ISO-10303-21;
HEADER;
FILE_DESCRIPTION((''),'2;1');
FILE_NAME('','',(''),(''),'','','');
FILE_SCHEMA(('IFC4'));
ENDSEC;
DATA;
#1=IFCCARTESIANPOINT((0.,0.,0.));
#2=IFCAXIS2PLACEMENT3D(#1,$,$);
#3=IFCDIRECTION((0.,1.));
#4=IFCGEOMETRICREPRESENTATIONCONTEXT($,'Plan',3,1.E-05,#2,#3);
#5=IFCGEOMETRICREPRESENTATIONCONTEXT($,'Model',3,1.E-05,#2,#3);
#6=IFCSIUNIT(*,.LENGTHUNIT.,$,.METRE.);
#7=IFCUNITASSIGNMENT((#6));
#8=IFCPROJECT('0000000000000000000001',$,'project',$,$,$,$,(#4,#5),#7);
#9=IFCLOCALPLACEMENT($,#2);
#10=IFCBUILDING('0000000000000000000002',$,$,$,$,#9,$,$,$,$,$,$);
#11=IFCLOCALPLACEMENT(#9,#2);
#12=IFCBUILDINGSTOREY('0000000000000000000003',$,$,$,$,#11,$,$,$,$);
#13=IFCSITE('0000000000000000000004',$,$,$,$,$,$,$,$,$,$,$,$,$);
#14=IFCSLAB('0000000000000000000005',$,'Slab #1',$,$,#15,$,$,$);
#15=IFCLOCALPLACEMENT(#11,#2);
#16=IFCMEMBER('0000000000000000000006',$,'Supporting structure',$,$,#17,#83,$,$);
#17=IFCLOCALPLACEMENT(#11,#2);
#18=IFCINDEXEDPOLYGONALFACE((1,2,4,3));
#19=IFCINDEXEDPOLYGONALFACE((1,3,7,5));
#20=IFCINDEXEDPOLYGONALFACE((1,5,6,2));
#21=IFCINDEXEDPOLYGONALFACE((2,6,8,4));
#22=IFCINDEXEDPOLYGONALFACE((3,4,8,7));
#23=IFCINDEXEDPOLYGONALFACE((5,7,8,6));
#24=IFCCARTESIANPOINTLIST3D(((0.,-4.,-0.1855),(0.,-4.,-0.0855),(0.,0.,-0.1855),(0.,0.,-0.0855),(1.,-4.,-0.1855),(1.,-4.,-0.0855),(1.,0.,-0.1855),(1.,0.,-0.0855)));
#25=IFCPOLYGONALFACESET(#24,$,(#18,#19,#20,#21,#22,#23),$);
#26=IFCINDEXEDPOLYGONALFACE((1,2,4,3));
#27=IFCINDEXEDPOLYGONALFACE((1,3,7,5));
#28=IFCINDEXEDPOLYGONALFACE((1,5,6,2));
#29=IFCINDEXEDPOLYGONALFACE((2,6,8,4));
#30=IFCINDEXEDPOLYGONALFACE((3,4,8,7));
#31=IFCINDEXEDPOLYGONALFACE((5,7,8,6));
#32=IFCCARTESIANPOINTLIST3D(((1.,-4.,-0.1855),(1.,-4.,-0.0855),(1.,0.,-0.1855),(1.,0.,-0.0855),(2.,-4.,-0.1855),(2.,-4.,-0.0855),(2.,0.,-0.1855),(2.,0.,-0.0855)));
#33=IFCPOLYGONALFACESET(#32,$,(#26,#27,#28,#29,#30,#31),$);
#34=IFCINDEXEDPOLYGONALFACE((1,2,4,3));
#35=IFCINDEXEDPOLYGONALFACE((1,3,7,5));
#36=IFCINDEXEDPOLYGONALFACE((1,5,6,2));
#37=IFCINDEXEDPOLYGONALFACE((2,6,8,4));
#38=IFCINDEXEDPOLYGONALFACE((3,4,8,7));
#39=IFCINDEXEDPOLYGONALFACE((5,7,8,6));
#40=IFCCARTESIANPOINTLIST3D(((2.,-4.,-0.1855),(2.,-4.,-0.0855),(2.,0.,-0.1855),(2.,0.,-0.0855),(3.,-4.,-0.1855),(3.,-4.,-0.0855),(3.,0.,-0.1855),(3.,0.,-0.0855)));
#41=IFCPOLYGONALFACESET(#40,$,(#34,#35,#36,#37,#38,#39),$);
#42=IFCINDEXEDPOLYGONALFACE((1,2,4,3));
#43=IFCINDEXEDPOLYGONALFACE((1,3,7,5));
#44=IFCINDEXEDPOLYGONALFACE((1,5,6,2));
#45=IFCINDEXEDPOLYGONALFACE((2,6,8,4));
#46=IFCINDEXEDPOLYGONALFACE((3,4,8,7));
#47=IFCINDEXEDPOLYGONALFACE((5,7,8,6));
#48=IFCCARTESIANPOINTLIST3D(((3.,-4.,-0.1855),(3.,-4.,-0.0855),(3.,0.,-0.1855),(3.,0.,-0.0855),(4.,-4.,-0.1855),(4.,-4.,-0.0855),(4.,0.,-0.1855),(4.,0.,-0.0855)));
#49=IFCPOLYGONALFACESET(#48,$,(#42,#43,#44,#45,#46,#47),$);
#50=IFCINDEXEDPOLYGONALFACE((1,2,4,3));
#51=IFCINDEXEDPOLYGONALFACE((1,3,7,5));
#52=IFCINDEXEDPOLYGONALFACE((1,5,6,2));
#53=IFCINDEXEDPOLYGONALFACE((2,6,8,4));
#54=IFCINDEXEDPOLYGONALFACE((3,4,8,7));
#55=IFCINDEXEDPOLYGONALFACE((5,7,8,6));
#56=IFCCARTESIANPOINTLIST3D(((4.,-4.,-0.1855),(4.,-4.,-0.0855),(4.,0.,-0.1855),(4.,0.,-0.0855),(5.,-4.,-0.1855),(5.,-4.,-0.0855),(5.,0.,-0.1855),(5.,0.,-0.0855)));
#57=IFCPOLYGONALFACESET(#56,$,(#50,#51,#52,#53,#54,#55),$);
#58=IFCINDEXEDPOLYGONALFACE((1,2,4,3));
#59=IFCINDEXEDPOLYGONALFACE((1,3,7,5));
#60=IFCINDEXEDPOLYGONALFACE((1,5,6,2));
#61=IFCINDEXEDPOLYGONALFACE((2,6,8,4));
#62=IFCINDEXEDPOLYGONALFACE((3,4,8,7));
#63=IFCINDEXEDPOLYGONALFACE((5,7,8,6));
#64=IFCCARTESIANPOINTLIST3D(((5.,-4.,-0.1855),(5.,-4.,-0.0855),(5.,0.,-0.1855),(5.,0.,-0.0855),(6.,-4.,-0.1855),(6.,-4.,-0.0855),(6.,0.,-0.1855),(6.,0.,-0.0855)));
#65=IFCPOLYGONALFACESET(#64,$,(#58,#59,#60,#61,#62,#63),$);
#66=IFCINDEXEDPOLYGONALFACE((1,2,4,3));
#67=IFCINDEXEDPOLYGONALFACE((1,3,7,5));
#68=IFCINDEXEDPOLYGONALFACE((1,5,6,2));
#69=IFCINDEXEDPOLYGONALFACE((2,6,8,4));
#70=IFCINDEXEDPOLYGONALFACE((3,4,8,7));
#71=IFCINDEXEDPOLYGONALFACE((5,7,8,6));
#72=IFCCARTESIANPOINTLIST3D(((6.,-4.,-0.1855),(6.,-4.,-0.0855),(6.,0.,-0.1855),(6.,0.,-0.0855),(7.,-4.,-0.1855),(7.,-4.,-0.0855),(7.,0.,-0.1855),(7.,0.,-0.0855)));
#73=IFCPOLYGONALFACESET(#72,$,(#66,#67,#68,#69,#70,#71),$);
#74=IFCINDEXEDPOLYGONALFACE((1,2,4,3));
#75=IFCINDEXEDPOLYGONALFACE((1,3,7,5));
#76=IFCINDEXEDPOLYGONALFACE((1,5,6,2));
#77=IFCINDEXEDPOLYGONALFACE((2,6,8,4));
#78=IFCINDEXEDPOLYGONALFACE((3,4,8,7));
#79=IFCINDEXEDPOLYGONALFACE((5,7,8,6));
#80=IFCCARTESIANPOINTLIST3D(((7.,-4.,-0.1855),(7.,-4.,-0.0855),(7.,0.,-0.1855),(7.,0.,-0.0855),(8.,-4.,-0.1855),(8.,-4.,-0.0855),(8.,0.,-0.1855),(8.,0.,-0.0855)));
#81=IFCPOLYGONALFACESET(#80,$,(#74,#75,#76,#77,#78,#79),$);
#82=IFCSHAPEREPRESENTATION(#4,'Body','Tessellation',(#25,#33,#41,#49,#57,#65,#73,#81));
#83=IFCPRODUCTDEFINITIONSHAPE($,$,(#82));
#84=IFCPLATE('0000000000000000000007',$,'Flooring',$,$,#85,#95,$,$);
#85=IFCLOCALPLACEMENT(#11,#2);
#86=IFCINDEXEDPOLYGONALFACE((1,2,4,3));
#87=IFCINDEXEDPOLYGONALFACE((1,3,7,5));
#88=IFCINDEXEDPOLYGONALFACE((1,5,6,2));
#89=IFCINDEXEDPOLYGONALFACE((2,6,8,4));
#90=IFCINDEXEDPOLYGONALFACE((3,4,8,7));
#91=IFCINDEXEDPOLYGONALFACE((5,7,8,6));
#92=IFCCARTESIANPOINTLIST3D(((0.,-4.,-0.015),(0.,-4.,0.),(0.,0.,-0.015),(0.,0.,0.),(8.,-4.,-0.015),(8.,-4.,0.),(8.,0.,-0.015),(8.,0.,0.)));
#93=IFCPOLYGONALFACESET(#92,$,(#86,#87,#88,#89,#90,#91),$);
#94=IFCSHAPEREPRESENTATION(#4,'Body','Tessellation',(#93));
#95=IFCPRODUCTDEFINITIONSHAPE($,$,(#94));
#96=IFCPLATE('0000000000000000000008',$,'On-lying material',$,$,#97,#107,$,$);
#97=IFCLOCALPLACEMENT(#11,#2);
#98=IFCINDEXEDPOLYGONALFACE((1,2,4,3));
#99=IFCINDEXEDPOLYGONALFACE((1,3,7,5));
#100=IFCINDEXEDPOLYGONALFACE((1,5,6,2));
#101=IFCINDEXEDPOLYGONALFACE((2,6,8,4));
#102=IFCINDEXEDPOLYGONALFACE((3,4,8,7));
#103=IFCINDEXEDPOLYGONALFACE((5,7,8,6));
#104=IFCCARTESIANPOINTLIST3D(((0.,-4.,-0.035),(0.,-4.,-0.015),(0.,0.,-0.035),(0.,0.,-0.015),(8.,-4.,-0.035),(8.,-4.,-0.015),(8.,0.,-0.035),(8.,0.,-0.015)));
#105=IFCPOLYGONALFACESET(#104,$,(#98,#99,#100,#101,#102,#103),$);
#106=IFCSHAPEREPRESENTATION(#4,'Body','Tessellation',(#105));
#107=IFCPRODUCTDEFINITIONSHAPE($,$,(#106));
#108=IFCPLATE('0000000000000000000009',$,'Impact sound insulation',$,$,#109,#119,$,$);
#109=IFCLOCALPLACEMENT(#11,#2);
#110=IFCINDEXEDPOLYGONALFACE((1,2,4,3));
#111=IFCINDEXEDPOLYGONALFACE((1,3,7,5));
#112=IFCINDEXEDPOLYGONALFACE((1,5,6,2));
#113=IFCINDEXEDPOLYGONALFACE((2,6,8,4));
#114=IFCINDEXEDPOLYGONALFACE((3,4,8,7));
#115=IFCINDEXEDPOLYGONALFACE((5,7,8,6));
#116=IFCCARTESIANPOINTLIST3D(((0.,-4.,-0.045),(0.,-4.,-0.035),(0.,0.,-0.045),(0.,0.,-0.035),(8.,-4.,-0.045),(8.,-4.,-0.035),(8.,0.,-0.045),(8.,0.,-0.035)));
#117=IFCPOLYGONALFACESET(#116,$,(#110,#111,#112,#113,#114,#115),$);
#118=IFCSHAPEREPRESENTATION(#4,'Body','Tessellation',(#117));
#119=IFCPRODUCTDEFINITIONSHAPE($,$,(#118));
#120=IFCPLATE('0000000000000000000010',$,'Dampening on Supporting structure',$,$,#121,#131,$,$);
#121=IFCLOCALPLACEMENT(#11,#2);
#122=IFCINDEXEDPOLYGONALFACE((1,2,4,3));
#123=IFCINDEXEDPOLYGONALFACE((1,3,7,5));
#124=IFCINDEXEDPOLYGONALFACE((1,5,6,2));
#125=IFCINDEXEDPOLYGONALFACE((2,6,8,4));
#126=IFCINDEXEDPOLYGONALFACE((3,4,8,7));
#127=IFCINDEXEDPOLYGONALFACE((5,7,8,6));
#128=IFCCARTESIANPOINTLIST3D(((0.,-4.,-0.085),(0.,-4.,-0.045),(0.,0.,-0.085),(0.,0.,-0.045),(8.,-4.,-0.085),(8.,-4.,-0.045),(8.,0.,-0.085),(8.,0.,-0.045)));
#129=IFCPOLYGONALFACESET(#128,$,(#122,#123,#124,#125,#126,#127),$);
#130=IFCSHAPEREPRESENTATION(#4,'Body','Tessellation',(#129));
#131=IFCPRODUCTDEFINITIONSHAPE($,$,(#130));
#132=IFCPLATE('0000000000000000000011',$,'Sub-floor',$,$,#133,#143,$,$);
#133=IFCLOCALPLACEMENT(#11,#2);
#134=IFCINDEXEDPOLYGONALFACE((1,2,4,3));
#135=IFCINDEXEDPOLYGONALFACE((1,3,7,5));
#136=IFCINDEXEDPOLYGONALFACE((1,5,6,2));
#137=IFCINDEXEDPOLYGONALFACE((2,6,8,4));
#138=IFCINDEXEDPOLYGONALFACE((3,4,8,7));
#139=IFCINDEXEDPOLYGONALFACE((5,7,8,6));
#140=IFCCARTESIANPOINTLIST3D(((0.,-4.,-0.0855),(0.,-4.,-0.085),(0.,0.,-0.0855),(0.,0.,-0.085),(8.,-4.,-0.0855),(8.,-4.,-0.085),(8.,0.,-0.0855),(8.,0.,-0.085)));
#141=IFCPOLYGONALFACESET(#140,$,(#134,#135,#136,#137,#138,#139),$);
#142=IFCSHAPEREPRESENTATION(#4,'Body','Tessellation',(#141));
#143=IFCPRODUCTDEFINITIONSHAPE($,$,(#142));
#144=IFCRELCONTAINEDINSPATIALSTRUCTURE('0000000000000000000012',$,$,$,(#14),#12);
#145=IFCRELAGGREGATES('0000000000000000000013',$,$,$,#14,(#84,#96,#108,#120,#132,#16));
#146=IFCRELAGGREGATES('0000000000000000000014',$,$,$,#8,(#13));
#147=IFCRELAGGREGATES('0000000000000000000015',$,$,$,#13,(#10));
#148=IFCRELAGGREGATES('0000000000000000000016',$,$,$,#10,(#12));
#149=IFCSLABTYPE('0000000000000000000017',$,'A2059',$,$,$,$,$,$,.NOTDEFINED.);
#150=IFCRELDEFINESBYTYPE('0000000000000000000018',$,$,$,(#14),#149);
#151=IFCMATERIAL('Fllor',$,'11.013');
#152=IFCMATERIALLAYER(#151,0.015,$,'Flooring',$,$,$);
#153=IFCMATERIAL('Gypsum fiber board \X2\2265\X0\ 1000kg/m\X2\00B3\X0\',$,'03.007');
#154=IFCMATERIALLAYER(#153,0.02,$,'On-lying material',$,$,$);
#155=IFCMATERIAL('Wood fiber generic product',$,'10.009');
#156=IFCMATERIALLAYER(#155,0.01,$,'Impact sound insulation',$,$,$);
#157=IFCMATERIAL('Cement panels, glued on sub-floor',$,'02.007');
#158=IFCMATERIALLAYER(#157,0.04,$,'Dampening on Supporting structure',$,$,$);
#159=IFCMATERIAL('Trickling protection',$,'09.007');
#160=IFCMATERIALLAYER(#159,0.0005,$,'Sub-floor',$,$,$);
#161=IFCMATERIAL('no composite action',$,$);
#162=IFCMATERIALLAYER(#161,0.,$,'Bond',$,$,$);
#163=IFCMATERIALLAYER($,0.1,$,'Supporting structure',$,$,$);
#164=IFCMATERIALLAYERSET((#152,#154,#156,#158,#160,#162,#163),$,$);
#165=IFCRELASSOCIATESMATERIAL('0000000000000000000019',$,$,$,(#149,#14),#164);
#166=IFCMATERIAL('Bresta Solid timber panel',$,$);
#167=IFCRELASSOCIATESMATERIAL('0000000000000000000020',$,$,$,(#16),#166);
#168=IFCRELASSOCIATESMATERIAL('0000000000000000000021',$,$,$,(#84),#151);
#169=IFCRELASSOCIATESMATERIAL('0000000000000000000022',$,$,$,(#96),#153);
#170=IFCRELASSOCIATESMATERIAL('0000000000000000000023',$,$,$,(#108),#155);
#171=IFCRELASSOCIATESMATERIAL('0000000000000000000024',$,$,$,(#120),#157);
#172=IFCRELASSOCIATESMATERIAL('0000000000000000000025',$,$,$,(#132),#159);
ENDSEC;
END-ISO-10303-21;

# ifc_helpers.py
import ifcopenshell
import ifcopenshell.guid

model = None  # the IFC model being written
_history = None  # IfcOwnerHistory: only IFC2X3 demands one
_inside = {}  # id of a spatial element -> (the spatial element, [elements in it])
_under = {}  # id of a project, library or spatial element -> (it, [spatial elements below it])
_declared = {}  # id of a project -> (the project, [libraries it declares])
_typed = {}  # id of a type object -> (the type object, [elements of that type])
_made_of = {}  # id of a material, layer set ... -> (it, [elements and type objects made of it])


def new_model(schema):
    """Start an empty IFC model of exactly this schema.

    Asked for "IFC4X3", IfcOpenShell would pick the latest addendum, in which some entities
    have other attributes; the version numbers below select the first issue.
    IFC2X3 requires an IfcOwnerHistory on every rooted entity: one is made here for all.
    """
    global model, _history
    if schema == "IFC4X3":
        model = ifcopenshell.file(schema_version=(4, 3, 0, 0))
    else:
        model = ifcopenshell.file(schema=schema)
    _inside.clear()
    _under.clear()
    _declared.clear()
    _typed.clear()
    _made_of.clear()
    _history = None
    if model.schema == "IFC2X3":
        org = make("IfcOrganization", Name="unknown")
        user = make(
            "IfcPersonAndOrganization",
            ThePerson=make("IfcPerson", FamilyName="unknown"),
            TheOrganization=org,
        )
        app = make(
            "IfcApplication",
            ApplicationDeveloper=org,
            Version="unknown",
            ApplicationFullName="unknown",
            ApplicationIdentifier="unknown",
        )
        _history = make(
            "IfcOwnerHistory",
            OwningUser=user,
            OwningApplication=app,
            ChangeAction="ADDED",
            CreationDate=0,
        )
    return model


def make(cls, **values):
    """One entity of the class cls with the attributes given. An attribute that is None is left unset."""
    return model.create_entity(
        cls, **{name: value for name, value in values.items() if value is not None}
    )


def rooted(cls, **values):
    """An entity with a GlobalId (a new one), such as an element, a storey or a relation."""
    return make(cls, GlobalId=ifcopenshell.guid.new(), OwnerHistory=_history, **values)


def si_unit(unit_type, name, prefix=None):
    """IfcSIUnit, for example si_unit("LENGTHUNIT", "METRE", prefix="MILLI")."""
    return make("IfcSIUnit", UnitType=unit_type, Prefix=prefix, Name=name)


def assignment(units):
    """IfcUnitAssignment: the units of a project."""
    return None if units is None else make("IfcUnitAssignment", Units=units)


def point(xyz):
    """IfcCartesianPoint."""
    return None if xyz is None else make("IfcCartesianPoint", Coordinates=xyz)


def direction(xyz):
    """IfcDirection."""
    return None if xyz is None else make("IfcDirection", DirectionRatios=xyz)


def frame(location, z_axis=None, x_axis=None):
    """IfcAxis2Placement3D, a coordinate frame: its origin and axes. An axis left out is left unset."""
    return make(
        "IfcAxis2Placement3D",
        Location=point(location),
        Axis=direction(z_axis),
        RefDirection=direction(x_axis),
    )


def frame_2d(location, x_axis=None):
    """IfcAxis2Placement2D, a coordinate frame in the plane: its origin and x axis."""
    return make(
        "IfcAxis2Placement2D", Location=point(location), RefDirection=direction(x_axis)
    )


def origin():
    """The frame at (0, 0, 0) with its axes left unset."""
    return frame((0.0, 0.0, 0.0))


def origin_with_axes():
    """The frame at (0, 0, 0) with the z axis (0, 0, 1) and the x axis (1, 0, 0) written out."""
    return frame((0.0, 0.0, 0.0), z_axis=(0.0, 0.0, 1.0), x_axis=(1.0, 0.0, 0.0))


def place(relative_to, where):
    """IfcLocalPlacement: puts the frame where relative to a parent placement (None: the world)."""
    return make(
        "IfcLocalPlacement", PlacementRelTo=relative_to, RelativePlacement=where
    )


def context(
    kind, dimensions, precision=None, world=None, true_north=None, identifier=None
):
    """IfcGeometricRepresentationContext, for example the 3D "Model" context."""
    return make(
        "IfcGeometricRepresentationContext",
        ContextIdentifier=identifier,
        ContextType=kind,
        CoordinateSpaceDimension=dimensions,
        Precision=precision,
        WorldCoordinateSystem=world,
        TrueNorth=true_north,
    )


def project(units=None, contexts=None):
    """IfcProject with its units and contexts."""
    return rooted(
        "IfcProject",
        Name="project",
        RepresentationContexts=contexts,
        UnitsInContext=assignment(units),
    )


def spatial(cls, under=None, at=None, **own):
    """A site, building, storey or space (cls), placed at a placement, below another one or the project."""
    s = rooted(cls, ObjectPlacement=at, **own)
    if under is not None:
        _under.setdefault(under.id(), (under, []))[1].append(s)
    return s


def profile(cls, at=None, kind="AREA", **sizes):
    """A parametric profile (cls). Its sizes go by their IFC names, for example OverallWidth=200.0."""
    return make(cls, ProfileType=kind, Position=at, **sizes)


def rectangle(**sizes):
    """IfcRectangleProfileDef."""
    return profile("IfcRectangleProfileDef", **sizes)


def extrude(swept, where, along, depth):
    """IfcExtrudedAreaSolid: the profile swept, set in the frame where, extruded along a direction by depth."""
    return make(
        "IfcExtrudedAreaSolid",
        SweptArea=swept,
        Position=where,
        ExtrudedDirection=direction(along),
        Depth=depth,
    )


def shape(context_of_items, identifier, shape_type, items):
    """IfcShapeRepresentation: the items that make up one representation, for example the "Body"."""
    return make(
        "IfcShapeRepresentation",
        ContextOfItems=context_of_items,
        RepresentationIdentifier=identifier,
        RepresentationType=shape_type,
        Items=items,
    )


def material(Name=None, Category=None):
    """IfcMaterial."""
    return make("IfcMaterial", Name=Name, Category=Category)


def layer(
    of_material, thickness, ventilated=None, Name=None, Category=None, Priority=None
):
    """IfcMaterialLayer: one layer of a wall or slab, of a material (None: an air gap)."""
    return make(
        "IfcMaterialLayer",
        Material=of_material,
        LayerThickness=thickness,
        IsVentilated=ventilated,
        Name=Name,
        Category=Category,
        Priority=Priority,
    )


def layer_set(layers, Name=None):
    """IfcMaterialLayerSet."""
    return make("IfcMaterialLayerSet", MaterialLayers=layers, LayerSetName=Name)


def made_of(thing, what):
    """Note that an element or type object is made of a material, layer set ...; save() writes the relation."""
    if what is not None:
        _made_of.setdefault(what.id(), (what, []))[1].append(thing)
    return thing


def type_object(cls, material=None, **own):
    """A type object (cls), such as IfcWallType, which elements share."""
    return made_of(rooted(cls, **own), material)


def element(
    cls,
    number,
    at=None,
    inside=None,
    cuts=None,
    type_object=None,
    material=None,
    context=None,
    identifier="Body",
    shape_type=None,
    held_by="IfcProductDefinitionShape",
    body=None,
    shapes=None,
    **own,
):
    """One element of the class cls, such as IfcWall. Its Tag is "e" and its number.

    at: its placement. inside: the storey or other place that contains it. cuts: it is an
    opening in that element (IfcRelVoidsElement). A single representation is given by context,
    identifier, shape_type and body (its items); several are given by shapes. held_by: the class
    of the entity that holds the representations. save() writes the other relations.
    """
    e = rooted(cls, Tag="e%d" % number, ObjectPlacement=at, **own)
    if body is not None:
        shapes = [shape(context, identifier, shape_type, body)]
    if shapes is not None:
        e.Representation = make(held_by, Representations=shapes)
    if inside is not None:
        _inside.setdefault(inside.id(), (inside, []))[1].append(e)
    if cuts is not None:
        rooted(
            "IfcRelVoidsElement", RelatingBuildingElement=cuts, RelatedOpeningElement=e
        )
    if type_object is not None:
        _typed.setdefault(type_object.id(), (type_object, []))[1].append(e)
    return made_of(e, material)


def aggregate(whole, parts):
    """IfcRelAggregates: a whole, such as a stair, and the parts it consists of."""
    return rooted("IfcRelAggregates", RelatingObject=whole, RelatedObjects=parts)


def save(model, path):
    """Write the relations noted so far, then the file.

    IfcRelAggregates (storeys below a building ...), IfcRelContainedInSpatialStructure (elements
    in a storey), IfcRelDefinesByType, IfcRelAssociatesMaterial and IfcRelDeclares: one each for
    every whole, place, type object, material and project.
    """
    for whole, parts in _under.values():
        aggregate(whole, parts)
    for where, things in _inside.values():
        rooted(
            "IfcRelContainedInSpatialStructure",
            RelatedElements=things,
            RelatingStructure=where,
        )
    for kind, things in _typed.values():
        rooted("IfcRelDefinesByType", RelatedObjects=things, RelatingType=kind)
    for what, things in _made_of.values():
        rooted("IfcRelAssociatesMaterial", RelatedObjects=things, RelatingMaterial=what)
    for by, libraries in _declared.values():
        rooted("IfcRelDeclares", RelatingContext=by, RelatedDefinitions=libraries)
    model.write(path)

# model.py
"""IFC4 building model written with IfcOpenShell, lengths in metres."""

from ifc_helpers import new_model, si_unit, direction, frame, frame_2d, origin, origin_with_axes, place, context, project, spatial, rectangle, extrude, material, layer, layer_set, type_object, element, aggregate, save


model = new_model("IFC4")

# Units and contexts
plan_context = context("Plan", 3, precision=1e-05, world=origin(), true_north=direction((0.0, 1.0)))
model_context = context("Model", 3, precision=1e-05, world=origin(), true_north=direction((0.0, 1.0)))
ifc_project = project(units=[si_unit("LENGTHUNIT", "METRE")], contexts=[plan_context, model_context])

# Site, building, storey
site = spatial("IfcSite", under=ifc_project)
building_placement = place(None, origin())
building = spatial("IfcBuilding", under=site, at=building_placement)
storey_placement = place(building_placement, origin())
storey = spatial("IfcBuildingStorey", under=building, at=storey_placement)

# Slab, member, plates
ifc_material_1 = material(Name="Fllor", Category="11.013")
ifc_layer_1 = layer(ifc_material_1, 0.015, Name="Flooring")
ifc_material_2 = material(Name="Gypsum fiber board ≥ 1000kg/m³", Category="03.007")
ifc_layer_2 = layer(ifc_material_2, 0.02, Name="On-lying material")
ifc_material_3 = material(Name="Wood fiber generic product", Category="10.009")
ifc_layer_3 = layer(ifc_material_3, 0.01, Name="Impact sound insulation")
ifc_material_4 = material(Name="Cement panels, glued on sub-floor", Category="02.007")
ifc_layer_4 = layer(ifc_material_4, 0.04, Name="Dampening on Supporting structure")
ifc_material_5 = material(Name="Trickling protection", Category="09.007")
ifc_layer_5 = layer(ifc_material_5, 0.0005, Name="Sub-floor")
ifc_material_6 = material(Name="no composite action")
ifc_layer_6 = layer(ifc_material_6, 0.0, Name="Bond")
ifc_layer_7 = layer(None, 0.1, Name="Supporting structure")
ifc_layer_set = layer_set([ifc_layer_1, ifc_layer_2, ifc_layer_3, ifc_layer_4, ifc_layer_5, ifc_layer_6, ifc_layer_7])
slab_type = type_object("IfcSlabType", Name="A2059", PredefinedType="NOTDEFINED", material=ifc_layer_set)
slab_placement = place(None, frame((0.0, 0.0, 0.0), z_axis=(0.0, 0.0, -1.0), x_axis=(1.0, 0.0, 0.0)))
slab = element("IfcSlab", 1, at=slab_placement, inside=storey, type_object=slab_type, material=ifc_layer_set, Name="Slab #1")
ifc_material_7 = material(Name="Bresta Solid timber panel")
member_placement = place(slab_placement, origin())
member = element("IfcMember", 2, at=member_placement, material=ifc_material_7, Name="Supporting structure", context=plan_context, shape_type="SweptSolid", body=[
    extrude(rectangle(XDim=1.0, YDim=0.1, at=frame_2d((0.5, 0.05), x_axis=(1.0, 0.0))), frame((0.0, 4.0, 0.0855), z_axis=(0.0, -1.0, 0.0), x_axis=(1.0, 0.0, 0.0)), (0.0, 0.0, 1.0), 4.0),
    extrude(rectangle(XDim=1.0, YDim=0.1, at=frame_2d((0.5, 0.05), x_axis=(1.0, 0.0))), frame((1.0, 4.0, 0.0855), z_axis=(0.0, -1.0, 0.0), x_axis=(1.0, 0.0, 0.0)), (0.0, 0.0, 1.0), 4.0),
    extrude(rectangle(XDim=1.0, YDim=0.1, at=frame_2d((0.5, 0.05), x_axis=(1.0, 0.0))), frame((2.0, 4.0, 0.0855), z_axis=(0.0, -1.0, 0.0), x_axis=(1.0, 0.0, 0.0)), (0.0, 0.0, 1.0), 4.0),
    extrude(rectangle(XDim=1.0, YDim=0.1, at=frame_2d((0.5, 0.05), x_axis=(1.0, 0.0))), frame((3.0, 4.0, 0.0855), z_axis=(0.0, -1.0, 0.0), x_axis=(1.0, 0.0, 0.0)), (0.0, 0.0, 1.0), 4.0),
    extrude(rectangle(XDim=1.0, YDim=0.1, at=frame_2d((0.5, 0.05), x_axis=(1.0, 0.0))), frame((4.0, 4.0, 0.0855), z_axis=(0.0, -1.0, 0.0), x_axis=(1.0, 0.0, 0.0)), (0.0, 0.0, 1.0), 4.0),
    extrude(rectangle(XDim=1.0, YDim=0.1, at=frame_2d((0.5, 0.05), x_axis=(1.0, 0.0))), frame((5.0, 4.0, 0.0855), z_axis=(0.0, -1.0, 0.0), x_axis=(1.0, 0.0, 0.0)), (0.0, 0.0, 1.0), 4.0),
    extrude(rectangle(XDim=1.0, YDim=0.1, at=frame_2d((0.5, 0.05), x_axis=(1.0, 0.0))), frame((6.0, 4.0, 0.0855), z_axis=(0.0, -1.0, 0.0), x_axis=(1.0, 0.0, 0.0)), (0.0, 0.0, 1.0), 4.0),
    extrude(rectangle(XDim=1.0, YDim=0.1, at=frame_2d((0.5, 0.05), x_axis=(1.0, 0.0))), frame((7.0, 4.0, 0.0855), z_axis=(0.0, -1.0, 0.0), x_axis=(1.0, 0.0, 0.0)), (0.0, 0.0, 1.0), 4.0),
])
plate_1_placement = place(slab_placement, origin())
plate_1 = element("IfcPlate", 3, at=plate_1_placement, material=ifc_material_1, Name="Flooring", context=plan_context, shape_type="SweptSolid", body=[
    extrude(rectangle(XDim=8.0, YDim=4.0, at=frame_2d((4.0, 2.0), x_axis=(1.0, 0.0))), origin_with_axes(), (0.0, 0.0, 1.0), 0.015),
])
plate_2_placement = place(slab_placement, origin())
plate_2 = element("IfcPlate", 4, at=plate_2_placement, material=ifc_material_2, Name="On-lying material", context=plan_context, shape_type="SweptSolid", body=[
    extrude(rectangle(XDim=8.0, YDim=4.0, at=frame_2d((4.0, 2.0), x_axis=(1.0, 0.0))), frame((0.0, 0.0, 0.015), z_axis=(0.0, 0.0, 1.0), x_axis=(1.0, 0.0, 0.0)), (0.0, 0.0, 1.0), 0.02),
])
plate_3_placement = place(slab_placement, origin())
plate_3 = element("IfcPlate", 5, at=plate_3_placement, material=ifc_material_3, Name="Impact sound insulation", context=plan_context, shape_type="SweptSolid", body=[
    extrude(rectangle(XDim=8.0, YDim=4.0, at=frame_2d((4.0, 2.0), x_axis=(1.0, 0.0))), frame((0.0, 0.0, 0.035), z_axis=(0.0, 0.0, 1.0), x_axis=(1.0, 0.0, 0.0)), (0.0, 0.0, 1.0), 0.01),
])
plate_4_placement = place(slab_placement, origin())
plate_4 = element("IfcPlate", 6, at=plate_4_placement, material=ifc_material_4, Name="Dampening on Supporting structure", context=plan_context, shape_type="SweptSolid", body=[
    extrude(rectangle(XDim=8.0, YDim=4.0, at=frame_2d((4.0, 2.0), x_axis=(1.0, 0.0))), frame((0.0, 0.0, 0.045), z_axis=(0.0, 0.0, 1.0), x_axis=(1.0, 0.0, 0.0)), (0.0, 0.0, 1.0), 0.04),
])
plate_5_placement = place(slab_placement, origin())
plate_5 = element("IfcPlate", 7, at=plate_5_placement, material=ifc_material_5, Name="Sub-floor", context=plan_context, shape_type="SweptSolid", body=[
    extrude(rectangle(XDim=8.0, YDim=4.0, at=frame_2d((4.0, 2.0), x_axis=(1.0, 0.0))), frame((0.0, 0.0, 0.085), z_axis=(0.0, 0.0, 1.0), x_axis=(1.0, 0.0, 0.0)), (0.0, 0.0, 1.0), 0.0005),
])
aggregate(slab, [plate_1, plate_2, plate_3, plate_4, plate_5, member])

save(model, "model.ifc")
